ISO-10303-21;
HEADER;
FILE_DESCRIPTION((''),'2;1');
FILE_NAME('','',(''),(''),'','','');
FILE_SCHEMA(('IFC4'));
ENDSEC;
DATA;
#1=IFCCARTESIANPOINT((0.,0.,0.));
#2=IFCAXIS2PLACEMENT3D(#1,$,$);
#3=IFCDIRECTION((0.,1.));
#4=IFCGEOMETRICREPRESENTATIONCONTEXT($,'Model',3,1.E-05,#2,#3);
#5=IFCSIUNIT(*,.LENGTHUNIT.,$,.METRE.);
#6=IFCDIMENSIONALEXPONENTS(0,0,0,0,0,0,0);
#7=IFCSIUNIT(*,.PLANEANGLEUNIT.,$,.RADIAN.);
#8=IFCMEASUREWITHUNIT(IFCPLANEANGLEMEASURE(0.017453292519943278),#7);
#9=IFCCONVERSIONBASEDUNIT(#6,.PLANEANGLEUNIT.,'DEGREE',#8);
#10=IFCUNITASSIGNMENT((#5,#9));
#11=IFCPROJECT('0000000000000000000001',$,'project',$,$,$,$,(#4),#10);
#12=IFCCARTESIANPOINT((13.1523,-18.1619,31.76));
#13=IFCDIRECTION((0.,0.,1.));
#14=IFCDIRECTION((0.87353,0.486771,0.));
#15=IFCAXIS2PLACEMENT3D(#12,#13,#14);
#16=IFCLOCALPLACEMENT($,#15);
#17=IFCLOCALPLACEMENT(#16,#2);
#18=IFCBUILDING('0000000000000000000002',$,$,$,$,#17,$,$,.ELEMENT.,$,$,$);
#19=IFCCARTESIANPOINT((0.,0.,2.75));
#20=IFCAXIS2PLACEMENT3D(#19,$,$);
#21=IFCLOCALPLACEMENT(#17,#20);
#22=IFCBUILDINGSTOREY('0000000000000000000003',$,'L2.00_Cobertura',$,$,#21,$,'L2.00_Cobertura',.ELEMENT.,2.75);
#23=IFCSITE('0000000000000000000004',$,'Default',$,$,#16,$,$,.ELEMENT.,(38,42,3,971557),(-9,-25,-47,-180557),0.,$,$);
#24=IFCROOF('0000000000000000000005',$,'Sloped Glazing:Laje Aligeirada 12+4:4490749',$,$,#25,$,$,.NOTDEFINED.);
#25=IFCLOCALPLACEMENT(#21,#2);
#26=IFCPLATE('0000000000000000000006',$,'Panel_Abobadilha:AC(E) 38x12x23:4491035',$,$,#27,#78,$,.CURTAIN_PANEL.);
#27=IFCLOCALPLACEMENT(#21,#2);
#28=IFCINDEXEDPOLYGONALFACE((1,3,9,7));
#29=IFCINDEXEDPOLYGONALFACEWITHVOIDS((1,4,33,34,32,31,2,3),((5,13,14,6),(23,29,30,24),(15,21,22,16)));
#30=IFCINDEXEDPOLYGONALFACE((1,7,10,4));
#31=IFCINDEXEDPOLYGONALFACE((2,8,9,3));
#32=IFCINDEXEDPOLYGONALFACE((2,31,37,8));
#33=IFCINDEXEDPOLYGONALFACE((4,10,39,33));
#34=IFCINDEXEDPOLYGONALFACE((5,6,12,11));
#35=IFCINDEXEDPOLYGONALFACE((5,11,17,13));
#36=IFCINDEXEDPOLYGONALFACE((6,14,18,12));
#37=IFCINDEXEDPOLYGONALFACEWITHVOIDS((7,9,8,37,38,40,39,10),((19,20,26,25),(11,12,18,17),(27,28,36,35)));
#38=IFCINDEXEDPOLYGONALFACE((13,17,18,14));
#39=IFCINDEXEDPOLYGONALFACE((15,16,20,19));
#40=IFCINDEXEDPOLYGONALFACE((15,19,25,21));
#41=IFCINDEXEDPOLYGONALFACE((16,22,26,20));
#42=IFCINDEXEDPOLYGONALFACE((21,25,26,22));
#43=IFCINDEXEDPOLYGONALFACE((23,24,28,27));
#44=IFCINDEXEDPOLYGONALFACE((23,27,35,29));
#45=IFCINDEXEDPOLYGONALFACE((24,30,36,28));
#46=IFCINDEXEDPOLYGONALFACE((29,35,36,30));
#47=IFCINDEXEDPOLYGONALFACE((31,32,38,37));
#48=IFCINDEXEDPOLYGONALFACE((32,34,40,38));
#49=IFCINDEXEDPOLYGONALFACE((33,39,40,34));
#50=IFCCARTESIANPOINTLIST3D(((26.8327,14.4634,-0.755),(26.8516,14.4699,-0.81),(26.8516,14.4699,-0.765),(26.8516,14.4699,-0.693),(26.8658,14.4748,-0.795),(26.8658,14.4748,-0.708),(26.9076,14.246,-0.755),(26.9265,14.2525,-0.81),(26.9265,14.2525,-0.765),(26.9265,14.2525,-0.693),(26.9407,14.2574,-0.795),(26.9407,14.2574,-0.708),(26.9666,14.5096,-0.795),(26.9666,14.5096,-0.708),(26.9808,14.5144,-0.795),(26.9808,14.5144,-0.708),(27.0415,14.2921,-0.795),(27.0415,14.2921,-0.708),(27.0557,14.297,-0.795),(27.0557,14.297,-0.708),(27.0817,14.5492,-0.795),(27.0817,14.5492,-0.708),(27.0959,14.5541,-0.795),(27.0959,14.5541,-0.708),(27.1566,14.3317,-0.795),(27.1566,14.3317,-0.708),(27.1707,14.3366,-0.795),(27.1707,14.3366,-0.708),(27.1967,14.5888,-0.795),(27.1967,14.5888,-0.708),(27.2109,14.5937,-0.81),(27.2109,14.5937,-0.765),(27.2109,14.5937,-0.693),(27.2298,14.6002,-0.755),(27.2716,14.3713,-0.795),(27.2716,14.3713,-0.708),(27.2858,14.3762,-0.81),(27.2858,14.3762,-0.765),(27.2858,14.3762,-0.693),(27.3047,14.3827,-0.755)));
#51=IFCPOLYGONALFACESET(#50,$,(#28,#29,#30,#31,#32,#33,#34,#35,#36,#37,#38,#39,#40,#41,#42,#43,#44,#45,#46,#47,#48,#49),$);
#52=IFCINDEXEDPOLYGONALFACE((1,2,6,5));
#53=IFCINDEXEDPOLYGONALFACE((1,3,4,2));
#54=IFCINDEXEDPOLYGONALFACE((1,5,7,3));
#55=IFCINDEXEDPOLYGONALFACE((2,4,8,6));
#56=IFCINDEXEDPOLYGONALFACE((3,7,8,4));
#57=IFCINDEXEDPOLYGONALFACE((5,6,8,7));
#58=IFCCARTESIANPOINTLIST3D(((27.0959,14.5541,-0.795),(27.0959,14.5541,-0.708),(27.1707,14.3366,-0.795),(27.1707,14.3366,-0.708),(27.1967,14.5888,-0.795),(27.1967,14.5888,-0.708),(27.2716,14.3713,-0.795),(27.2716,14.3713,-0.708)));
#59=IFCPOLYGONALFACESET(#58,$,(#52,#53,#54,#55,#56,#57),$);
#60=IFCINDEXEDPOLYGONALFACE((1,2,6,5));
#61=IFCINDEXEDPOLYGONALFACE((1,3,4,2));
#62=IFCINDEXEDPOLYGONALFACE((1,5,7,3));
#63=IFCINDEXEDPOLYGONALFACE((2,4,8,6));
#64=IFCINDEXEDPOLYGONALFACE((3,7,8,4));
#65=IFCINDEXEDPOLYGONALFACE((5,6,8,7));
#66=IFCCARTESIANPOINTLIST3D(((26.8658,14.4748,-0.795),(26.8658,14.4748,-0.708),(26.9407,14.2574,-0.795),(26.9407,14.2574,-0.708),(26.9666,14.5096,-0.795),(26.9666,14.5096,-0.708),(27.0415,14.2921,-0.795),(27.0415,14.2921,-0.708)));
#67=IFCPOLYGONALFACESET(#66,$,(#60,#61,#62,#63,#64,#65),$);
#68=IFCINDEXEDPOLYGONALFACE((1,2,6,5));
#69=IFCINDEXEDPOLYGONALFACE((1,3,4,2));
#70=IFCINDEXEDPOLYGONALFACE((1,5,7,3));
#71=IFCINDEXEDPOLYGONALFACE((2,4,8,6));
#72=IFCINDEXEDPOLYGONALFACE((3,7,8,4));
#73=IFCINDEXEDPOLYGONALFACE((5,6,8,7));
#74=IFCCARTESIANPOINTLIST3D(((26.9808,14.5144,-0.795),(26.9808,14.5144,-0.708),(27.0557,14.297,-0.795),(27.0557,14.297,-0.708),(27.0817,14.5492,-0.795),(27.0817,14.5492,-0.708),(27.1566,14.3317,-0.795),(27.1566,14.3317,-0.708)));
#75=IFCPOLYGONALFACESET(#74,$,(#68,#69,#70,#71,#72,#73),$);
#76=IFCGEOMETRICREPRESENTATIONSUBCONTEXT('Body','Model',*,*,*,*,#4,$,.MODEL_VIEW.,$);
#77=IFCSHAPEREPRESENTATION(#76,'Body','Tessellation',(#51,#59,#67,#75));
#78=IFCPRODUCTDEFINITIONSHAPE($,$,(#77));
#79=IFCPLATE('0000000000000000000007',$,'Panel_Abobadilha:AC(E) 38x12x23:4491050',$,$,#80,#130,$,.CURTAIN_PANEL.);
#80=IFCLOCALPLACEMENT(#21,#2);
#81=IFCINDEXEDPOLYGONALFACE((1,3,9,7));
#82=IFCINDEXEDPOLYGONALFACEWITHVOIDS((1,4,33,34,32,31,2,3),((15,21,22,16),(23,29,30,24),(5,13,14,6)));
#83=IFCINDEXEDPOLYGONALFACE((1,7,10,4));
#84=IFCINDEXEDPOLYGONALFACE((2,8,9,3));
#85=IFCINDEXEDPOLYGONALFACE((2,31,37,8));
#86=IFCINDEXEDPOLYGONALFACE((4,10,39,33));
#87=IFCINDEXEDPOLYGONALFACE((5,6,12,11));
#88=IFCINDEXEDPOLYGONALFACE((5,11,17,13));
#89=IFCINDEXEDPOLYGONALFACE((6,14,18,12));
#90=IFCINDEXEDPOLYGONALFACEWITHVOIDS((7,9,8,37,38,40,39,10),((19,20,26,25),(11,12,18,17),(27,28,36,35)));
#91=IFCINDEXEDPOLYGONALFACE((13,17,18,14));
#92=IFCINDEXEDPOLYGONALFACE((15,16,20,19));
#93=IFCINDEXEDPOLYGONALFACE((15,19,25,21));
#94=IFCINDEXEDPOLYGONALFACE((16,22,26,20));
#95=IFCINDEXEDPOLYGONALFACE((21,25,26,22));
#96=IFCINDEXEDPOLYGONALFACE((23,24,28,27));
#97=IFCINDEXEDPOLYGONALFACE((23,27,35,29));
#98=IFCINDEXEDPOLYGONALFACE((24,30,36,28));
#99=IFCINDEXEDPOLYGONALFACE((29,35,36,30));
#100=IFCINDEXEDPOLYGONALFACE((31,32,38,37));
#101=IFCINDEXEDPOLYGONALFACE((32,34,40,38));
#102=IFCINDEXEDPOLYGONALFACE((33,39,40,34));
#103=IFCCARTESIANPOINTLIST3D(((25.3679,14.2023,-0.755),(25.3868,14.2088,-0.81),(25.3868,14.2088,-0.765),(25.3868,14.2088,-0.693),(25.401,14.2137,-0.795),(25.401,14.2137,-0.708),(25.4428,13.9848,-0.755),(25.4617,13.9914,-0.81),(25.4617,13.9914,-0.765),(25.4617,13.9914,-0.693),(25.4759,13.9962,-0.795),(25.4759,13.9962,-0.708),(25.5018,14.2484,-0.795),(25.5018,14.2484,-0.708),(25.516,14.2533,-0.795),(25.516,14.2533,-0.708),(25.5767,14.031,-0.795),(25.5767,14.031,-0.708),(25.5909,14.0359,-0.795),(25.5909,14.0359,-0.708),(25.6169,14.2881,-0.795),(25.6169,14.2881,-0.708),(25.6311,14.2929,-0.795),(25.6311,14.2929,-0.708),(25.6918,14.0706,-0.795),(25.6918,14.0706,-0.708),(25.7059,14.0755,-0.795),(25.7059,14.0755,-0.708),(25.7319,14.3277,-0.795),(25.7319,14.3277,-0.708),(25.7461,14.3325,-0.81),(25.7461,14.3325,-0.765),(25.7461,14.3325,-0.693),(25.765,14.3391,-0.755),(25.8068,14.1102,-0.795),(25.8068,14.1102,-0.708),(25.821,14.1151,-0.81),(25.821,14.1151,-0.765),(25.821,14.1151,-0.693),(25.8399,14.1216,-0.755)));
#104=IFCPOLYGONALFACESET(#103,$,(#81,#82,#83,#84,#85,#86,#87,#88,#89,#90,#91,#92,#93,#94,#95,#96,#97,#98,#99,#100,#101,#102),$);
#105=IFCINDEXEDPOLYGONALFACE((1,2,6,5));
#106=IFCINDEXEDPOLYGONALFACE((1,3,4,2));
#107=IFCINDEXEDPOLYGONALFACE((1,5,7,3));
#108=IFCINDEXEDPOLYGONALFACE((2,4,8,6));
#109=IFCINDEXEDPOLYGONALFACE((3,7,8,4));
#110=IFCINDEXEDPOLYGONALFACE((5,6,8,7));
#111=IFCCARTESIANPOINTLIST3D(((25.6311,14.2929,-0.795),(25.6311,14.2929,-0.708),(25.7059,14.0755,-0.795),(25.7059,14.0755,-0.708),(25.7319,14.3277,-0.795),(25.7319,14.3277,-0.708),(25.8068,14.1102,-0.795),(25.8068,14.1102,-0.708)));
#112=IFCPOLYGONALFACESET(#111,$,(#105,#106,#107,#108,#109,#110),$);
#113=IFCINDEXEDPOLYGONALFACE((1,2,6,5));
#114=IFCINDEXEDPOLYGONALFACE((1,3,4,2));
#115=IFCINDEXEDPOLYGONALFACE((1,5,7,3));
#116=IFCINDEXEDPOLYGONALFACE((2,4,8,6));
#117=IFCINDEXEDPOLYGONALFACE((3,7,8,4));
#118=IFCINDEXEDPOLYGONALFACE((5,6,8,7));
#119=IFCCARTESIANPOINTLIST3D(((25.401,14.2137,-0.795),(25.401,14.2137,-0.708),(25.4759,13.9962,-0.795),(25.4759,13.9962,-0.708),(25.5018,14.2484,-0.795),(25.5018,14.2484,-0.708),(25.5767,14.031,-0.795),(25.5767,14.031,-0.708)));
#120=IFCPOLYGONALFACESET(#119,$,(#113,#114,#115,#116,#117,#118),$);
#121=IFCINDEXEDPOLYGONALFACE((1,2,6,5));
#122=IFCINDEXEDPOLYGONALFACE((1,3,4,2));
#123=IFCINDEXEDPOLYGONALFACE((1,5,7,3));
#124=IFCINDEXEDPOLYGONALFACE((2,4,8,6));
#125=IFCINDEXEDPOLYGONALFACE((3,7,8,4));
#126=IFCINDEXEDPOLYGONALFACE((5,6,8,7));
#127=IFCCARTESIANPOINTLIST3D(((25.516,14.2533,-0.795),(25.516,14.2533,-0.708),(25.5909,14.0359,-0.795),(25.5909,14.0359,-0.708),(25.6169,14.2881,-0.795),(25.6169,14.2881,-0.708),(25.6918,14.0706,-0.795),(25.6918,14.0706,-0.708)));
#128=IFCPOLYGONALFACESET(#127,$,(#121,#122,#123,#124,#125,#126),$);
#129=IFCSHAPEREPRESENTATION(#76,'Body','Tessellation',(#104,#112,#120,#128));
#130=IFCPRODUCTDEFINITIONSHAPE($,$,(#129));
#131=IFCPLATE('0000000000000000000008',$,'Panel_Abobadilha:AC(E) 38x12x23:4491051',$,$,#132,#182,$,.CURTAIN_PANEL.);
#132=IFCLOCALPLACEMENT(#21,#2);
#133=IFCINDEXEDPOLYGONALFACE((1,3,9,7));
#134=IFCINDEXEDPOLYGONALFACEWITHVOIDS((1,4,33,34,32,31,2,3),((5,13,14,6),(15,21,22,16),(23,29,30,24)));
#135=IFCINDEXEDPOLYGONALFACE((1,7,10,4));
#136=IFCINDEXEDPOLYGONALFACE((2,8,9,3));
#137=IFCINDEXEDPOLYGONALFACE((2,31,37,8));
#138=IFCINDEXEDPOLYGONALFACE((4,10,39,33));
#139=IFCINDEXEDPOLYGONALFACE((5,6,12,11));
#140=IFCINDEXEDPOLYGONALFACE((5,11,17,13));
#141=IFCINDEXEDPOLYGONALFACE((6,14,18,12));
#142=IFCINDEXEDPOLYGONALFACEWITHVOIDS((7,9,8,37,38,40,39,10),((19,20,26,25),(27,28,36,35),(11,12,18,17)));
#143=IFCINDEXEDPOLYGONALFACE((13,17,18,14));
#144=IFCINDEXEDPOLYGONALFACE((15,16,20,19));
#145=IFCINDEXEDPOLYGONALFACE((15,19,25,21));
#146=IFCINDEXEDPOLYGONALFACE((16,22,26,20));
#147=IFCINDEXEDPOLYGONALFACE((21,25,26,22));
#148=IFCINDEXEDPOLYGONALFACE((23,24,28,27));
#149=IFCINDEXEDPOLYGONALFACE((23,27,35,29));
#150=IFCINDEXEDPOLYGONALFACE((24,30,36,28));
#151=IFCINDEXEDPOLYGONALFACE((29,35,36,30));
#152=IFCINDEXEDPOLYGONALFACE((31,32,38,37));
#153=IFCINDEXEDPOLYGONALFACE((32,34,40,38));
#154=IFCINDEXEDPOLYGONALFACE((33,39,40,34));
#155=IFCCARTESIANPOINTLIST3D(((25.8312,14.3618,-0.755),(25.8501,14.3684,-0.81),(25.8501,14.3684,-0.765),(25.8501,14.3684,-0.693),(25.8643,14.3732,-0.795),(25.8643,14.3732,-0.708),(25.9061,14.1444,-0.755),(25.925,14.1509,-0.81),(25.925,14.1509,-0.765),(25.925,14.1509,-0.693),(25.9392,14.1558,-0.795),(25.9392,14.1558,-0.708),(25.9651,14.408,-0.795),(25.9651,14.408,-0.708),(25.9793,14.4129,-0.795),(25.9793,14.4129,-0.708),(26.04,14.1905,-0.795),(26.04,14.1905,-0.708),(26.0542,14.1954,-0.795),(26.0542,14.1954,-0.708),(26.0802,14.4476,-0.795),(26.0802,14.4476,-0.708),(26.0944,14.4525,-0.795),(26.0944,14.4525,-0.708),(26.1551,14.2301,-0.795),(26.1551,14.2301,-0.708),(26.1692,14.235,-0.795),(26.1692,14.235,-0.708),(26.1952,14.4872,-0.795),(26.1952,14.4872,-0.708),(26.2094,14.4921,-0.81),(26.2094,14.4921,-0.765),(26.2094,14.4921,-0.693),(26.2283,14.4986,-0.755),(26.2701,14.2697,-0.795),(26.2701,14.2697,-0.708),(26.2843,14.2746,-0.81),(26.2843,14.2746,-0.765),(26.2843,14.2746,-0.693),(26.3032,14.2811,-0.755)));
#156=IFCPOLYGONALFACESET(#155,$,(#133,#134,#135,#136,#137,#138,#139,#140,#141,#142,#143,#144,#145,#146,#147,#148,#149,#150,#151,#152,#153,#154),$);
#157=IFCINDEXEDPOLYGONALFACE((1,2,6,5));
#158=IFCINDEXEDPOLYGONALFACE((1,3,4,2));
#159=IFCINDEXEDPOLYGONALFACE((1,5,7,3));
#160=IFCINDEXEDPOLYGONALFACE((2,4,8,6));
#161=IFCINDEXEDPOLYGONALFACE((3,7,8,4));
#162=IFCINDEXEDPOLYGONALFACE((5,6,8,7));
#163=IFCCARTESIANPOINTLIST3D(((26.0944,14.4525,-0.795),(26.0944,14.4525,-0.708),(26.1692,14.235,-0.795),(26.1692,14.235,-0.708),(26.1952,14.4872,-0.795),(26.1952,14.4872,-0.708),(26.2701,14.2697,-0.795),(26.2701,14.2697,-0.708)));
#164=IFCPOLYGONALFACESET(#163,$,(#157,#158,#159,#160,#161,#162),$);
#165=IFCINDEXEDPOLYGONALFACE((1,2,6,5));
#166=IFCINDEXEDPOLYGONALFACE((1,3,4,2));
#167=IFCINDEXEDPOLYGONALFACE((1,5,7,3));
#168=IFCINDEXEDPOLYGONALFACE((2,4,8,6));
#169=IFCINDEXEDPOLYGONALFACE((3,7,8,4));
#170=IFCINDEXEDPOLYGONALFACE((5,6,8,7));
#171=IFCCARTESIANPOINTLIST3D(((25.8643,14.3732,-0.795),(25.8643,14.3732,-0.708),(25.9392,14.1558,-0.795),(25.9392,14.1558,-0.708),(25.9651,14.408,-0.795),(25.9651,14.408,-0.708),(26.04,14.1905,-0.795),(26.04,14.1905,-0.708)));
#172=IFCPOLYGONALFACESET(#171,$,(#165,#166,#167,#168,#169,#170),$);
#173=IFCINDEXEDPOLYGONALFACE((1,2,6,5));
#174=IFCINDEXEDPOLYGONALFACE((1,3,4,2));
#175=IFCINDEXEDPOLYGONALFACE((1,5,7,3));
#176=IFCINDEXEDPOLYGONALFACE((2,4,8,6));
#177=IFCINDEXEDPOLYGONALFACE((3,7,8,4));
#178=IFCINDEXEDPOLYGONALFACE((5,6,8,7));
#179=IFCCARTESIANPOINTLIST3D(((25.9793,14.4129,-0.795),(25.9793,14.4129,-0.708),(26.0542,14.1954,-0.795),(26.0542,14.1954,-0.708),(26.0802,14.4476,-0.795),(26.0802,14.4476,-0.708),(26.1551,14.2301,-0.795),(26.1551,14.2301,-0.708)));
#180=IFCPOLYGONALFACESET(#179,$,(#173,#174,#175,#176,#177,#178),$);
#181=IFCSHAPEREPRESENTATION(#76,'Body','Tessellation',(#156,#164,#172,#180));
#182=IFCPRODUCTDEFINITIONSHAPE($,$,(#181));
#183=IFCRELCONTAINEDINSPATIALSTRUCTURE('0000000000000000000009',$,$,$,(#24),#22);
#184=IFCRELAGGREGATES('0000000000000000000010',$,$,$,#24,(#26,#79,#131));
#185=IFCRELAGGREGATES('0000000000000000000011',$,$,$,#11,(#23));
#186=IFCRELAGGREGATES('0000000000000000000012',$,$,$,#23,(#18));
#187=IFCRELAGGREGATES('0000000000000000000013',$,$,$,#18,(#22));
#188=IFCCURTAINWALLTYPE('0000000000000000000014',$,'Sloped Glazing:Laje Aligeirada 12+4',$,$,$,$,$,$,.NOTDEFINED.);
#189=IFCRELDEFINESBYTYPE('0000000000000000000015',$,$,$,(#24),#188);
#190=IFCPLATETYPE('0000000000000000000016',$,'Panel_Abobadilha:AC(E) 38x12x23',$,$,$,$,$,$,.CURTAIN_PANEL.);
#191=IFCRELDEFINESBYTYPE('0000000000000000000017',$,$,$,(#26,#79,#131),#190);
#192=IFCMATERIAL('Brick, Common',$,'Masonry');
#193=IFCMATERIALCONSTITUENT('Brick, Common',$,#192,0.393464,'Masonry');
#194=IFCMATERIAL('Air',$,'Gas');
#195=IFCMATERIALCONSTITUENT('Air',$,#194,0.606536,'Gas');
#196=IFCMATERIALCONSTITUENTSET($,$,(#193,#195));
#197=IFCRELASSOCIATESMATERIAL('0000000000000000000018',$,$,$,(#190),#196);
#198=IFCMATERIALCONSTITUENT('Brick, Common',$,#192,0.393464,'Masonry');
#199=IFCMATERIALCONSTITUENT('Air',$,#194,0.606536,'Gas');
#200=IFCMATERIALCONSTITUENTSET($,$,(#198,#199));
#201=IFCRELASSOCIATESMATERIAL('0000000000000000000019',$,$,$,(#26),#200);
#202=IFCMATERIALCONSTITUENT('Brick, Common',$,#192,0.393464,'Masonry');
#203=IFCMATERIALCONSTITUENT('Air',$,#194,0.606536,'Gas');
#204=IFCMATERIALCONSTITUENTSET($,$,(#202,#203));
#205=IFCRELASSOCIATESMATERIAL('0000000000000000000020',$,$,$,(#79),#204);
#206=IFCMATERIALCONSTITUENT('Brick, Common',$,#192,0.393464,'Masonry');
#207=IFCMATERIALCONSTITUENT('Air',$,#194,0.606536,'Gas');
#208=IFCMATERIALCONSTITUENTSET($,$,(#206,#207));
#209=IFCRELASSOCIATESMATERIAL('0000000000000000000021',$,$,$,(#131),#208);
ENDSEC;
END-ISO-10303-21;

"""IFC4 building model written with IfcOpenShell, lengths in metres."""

from ifc_helpers import new_model, entity, si_unit, converted_unit, direction, frame, origin, place, context, subcontext, project, spatial, indexed_curve, outline, extrude, source, transform, mapped, material, constituent, constituent_set, type_object, type_shapes, element, aggregate, save


model = new_model("IFC4")

# Units and contexts
model_context = context("Model", 3, precision=1e-05, world=origin(), true_north=direction((0.0, 1.0)))
body_context = subcontext(model_context, "Body", "Model", "MODEL_VIEW")
ifc_project = project(units=[si_unit("LENGTHUNIT", "METRE"), converted_unit("PLANEANGLEUNIT", "DEGREE", entity("IfcPlaneAngleMeasure", 0.017453292519943278), si_unit("PLANEANGLEUNIT", "RADIAN"), dimensions=[0, 0, 0, 0, 0, 0, 0])], contexts=[model_context])

# Site, building, storey
site_placement = place(None, frame((13.1523, -18.1619, 31.76), z_axis=(0.0, 0.0, 1.0), x_axis=(0.87353, 0.486771, 0.0)))
site = spatial("IfcSite", under=ifc_project, at=site_placement, Name="Default", CompositionType="ELEMENT", RefLatitude=(38, 42, 3, 971557), RefLongitude=(-9, -25, -47, -180557), RefElevation=0.0)
building_placement = place(site_placement, origin())
building = spatial("IfcBuilding", under=site, at=building_placement, CompositionType="ELEMENT")
storey_placement = place(building_placement, frame((0.0, 0.0, 2.75)))
storey = spatial("IfcBuildingStorey", under=building, at=storey_placement, Name="L2.00_Cobertura", LongName="L2.00_Cobertura", CompositionType="ELEMENT", Elevation=2.75)

# Roof, plates
curtain_wall_type = type_object("IfcCurtainWallType", Name="Sloped Glazing:Laje Aligeirada 12+4", PredefinedType="NOTDEFINED")
roof_placement = place(storey_placement, frame((0.0, 0.0, -2.75)))
roof = element("IfcRoof", 1, at=roof_placement, inside=storey, type_object=curtain_wall_type, Name="Sloped Glazing:Laje Aligeirada 12+4:4490749", PredefinedType="NOTDEFINED")
ifc_material_1 = material(Name="Brick, Common", Category="Masonry")
ifc_material_2 = material(Name="Air", Category="Gas")
ifc_constituent_1 = constituent(ifc_material_1, Name="Brick, Common", Category="Masonry", fraction=0.393464)
ifc_constituent_2 = constituent(ifc_material_2, Name="Air", Category="Gas", fraction=0.606536)
ifc_constituent_set_1 = constituent_set(constituents=[ifc_constituent_1, ifc_constituent_2])
plate_type = type_object("IfcPlateType", Name="Panel_Abobadilha:AC(E) 38x12x23", PredefinedType="CURTAIN_PANEL", material=ifc_constituent_set_1)
shared_shape_1 = source(origin(), body_context, "Body", "SweptSolid", [
    extrude(outline(indexed_curve([(-0.19, -0.0543), (0.19, -0.0543), (0.19, -0.0093), (0.21, 0.0007), (0.19, 0.0628), (-0.19, 0.0628), (-0.21, 0.0007), (-0.19, -0.0093), (-0.19, -0.0543)], self_intersect=False), holes=[indexed_curve([(-0.0683, 0.0477), (-0.0683, -0.0393), (-0.175, -0.0393), (-0.175, 0.0477), (-0.0683, 0.0477)], self_intersect=False), indexed_curve([(0.0533, 0.0477), (0.0533, -0.0393), (-0.0533, -0.0393), (-0.0533, 0.0477), (0.0533, 0.0477)], self_intersect=False), indexed_curve([(0.175, 0.0477), (0.175, -0.0393), (0.0683, -0.0393), (0.0683, 0.0477), (0.175, 0.0477)], self_intersect=False)]), frame((0.0, 0.0543, 0.0)), (0.0, 0.0, 1.0), 0.23),
    extrude(outline(indexed_curve([(-0.0533, -0.0435), (0.0533, -0.0435), (0.0533, 0.0435), (-0.0533, 0.0435), (-0.0533, -0.0435)], self_intersect=False)), frame((0.1217, 0.0585, 0.0), z_axis=(0.0, 0.0, 1.0), x_axis=(-1.0, 0.0, 0.0)), (0.0, 0.0, 1.0), 0.23),
    extrude(outline(indexed_curve([(-0.0533, -0.0435), (0.0533, -0.0435), (0.0533, 0.0435), (-0.0533, 0.0435), (-0.0533, -0.0435)], self_intersect=False)), frame((-0.1217, 0.0585, 0.0), z_axis=(0.0, 0.0, 1.0), x_axis=(-1.0, 0.0, 0.0)), (0.0, 0.0, 1.0), 0.23),
    extrude(outline(indexed_curve([(-0.0533, -0.0435), (0.0533, -0.0435), (0.0533, 0.0435), (-0.0533, 0.0435), (-0.0533, -0.0435)], self_intersect=False)), frame((0.0, 0.0585, 0.0), z_axis=(0.0, 0.0, 1.0), x_axis=(-1.0, 0.0, 0.0)), (0.0, 0.0, 1.0), 0.23),
])
type_shapes(plate_type, [shared_shape_1])
ifc_constituent_3 = constituent(ifc_material_1, Name="Brick, Common", Category="Masonry", fraction=0.393464)
ifc_constituent_4 = constituent(ifc_material_2, Name="Air", Category="Gas", fraction=0.606536)
ifc_constituent_set_2 = constituent_set(constituents=[ifc_constituent_3, ifc_constituent_4])
plate_1_placement = place(roof_placement, frame((27.0312, 14.5318, 1.94), z_axis=(0.325568, -0.945519, 0.0), x_axis=(0.945519, 0.325568, 0.0)))
plate_1 = element("IfcPlate", 2, at=plate_1_placement, type_object=plate_type, material=ifc_constituent_set_2, Name="Panel_Abobadilha:AC(E) 38x12x23:4491035", PredefinedType="CURTAIN_PANEL", context=body_context, shape_type="MappedRepresentation", body=[
    mapped(shared_shape_1, transform((0.0, 0.0, 0.0), scale=1.0)),
])
ifc_constituent_5 = constituent(ifc_material_1, Name="Brick, Common", Category="Masonry", fraction=0.393464)
ifc_constituent_6 = constituent(ifc_material_2, Name="Air", Category="Gas", fraction=0.606536)
ifc_constituent_set_3 = constituent_set(constituents=[ifc_constituent_5, ifc_constituent_6])
plate_2_placement = place(roof_placement, frame((25.5665, 14.2707, 1.94), z_axis=(0.325568, -0.945519, 0.0), x_axis=(0.945519, 0.325568, 0.0)))
plate_2 = element("IfcPlate", 3, at=plate_2_placement, type_object=plate_type, material=ifc_constituent_set_3, Name="Panel_Abobadilha:AC(E) 38x12x23:4491050", PredefinedType="CURTAIN_PANEL", context=body_context, shape_type="MappedRepresentation", body=[
    mapped(shared_shape_1, transform((0.0, 0.0, 0.0), scale=1.0)),
])
ifc_constituent_7 = constituent(ifc_material_1, Name="Brick, Common", Category="Masonry", fraction=0.393464)
ifc_constituent_8 = constituent(ifc_material_2, Name="Air", Category="Gas", fraction=0.606536)
ifc_constituent_set_4 = constituent_set(constituents=[ifc_constituent_7, ifc_constituent_8])
plate_3_placement = place(roof_placement, frame((26.0298, 14.4302, 1.94), z_axis=(0.325568, -0.945519, 0.0), x_axis=(0.945519, 0.325568, 0.0)))
plate_3 = element("IfcPlate", 4, at=plate_3_placement, type_object=plate_type, material=ifc_constituent_set_4, Name="Panel_Abobadilha:AC(E) 38x12x23:4491051", PredefinedType="CURTAIN_PANEL", context=body_context, shape_type="MappedRepresentation", body=[
    mapped(shared_shape_1, transform((0.0, 0.0, 0.0), scale=1.0)),
])
aggregate(roof, [plate_1, plate_2, plate_3])

save(model, "model.ifc")
